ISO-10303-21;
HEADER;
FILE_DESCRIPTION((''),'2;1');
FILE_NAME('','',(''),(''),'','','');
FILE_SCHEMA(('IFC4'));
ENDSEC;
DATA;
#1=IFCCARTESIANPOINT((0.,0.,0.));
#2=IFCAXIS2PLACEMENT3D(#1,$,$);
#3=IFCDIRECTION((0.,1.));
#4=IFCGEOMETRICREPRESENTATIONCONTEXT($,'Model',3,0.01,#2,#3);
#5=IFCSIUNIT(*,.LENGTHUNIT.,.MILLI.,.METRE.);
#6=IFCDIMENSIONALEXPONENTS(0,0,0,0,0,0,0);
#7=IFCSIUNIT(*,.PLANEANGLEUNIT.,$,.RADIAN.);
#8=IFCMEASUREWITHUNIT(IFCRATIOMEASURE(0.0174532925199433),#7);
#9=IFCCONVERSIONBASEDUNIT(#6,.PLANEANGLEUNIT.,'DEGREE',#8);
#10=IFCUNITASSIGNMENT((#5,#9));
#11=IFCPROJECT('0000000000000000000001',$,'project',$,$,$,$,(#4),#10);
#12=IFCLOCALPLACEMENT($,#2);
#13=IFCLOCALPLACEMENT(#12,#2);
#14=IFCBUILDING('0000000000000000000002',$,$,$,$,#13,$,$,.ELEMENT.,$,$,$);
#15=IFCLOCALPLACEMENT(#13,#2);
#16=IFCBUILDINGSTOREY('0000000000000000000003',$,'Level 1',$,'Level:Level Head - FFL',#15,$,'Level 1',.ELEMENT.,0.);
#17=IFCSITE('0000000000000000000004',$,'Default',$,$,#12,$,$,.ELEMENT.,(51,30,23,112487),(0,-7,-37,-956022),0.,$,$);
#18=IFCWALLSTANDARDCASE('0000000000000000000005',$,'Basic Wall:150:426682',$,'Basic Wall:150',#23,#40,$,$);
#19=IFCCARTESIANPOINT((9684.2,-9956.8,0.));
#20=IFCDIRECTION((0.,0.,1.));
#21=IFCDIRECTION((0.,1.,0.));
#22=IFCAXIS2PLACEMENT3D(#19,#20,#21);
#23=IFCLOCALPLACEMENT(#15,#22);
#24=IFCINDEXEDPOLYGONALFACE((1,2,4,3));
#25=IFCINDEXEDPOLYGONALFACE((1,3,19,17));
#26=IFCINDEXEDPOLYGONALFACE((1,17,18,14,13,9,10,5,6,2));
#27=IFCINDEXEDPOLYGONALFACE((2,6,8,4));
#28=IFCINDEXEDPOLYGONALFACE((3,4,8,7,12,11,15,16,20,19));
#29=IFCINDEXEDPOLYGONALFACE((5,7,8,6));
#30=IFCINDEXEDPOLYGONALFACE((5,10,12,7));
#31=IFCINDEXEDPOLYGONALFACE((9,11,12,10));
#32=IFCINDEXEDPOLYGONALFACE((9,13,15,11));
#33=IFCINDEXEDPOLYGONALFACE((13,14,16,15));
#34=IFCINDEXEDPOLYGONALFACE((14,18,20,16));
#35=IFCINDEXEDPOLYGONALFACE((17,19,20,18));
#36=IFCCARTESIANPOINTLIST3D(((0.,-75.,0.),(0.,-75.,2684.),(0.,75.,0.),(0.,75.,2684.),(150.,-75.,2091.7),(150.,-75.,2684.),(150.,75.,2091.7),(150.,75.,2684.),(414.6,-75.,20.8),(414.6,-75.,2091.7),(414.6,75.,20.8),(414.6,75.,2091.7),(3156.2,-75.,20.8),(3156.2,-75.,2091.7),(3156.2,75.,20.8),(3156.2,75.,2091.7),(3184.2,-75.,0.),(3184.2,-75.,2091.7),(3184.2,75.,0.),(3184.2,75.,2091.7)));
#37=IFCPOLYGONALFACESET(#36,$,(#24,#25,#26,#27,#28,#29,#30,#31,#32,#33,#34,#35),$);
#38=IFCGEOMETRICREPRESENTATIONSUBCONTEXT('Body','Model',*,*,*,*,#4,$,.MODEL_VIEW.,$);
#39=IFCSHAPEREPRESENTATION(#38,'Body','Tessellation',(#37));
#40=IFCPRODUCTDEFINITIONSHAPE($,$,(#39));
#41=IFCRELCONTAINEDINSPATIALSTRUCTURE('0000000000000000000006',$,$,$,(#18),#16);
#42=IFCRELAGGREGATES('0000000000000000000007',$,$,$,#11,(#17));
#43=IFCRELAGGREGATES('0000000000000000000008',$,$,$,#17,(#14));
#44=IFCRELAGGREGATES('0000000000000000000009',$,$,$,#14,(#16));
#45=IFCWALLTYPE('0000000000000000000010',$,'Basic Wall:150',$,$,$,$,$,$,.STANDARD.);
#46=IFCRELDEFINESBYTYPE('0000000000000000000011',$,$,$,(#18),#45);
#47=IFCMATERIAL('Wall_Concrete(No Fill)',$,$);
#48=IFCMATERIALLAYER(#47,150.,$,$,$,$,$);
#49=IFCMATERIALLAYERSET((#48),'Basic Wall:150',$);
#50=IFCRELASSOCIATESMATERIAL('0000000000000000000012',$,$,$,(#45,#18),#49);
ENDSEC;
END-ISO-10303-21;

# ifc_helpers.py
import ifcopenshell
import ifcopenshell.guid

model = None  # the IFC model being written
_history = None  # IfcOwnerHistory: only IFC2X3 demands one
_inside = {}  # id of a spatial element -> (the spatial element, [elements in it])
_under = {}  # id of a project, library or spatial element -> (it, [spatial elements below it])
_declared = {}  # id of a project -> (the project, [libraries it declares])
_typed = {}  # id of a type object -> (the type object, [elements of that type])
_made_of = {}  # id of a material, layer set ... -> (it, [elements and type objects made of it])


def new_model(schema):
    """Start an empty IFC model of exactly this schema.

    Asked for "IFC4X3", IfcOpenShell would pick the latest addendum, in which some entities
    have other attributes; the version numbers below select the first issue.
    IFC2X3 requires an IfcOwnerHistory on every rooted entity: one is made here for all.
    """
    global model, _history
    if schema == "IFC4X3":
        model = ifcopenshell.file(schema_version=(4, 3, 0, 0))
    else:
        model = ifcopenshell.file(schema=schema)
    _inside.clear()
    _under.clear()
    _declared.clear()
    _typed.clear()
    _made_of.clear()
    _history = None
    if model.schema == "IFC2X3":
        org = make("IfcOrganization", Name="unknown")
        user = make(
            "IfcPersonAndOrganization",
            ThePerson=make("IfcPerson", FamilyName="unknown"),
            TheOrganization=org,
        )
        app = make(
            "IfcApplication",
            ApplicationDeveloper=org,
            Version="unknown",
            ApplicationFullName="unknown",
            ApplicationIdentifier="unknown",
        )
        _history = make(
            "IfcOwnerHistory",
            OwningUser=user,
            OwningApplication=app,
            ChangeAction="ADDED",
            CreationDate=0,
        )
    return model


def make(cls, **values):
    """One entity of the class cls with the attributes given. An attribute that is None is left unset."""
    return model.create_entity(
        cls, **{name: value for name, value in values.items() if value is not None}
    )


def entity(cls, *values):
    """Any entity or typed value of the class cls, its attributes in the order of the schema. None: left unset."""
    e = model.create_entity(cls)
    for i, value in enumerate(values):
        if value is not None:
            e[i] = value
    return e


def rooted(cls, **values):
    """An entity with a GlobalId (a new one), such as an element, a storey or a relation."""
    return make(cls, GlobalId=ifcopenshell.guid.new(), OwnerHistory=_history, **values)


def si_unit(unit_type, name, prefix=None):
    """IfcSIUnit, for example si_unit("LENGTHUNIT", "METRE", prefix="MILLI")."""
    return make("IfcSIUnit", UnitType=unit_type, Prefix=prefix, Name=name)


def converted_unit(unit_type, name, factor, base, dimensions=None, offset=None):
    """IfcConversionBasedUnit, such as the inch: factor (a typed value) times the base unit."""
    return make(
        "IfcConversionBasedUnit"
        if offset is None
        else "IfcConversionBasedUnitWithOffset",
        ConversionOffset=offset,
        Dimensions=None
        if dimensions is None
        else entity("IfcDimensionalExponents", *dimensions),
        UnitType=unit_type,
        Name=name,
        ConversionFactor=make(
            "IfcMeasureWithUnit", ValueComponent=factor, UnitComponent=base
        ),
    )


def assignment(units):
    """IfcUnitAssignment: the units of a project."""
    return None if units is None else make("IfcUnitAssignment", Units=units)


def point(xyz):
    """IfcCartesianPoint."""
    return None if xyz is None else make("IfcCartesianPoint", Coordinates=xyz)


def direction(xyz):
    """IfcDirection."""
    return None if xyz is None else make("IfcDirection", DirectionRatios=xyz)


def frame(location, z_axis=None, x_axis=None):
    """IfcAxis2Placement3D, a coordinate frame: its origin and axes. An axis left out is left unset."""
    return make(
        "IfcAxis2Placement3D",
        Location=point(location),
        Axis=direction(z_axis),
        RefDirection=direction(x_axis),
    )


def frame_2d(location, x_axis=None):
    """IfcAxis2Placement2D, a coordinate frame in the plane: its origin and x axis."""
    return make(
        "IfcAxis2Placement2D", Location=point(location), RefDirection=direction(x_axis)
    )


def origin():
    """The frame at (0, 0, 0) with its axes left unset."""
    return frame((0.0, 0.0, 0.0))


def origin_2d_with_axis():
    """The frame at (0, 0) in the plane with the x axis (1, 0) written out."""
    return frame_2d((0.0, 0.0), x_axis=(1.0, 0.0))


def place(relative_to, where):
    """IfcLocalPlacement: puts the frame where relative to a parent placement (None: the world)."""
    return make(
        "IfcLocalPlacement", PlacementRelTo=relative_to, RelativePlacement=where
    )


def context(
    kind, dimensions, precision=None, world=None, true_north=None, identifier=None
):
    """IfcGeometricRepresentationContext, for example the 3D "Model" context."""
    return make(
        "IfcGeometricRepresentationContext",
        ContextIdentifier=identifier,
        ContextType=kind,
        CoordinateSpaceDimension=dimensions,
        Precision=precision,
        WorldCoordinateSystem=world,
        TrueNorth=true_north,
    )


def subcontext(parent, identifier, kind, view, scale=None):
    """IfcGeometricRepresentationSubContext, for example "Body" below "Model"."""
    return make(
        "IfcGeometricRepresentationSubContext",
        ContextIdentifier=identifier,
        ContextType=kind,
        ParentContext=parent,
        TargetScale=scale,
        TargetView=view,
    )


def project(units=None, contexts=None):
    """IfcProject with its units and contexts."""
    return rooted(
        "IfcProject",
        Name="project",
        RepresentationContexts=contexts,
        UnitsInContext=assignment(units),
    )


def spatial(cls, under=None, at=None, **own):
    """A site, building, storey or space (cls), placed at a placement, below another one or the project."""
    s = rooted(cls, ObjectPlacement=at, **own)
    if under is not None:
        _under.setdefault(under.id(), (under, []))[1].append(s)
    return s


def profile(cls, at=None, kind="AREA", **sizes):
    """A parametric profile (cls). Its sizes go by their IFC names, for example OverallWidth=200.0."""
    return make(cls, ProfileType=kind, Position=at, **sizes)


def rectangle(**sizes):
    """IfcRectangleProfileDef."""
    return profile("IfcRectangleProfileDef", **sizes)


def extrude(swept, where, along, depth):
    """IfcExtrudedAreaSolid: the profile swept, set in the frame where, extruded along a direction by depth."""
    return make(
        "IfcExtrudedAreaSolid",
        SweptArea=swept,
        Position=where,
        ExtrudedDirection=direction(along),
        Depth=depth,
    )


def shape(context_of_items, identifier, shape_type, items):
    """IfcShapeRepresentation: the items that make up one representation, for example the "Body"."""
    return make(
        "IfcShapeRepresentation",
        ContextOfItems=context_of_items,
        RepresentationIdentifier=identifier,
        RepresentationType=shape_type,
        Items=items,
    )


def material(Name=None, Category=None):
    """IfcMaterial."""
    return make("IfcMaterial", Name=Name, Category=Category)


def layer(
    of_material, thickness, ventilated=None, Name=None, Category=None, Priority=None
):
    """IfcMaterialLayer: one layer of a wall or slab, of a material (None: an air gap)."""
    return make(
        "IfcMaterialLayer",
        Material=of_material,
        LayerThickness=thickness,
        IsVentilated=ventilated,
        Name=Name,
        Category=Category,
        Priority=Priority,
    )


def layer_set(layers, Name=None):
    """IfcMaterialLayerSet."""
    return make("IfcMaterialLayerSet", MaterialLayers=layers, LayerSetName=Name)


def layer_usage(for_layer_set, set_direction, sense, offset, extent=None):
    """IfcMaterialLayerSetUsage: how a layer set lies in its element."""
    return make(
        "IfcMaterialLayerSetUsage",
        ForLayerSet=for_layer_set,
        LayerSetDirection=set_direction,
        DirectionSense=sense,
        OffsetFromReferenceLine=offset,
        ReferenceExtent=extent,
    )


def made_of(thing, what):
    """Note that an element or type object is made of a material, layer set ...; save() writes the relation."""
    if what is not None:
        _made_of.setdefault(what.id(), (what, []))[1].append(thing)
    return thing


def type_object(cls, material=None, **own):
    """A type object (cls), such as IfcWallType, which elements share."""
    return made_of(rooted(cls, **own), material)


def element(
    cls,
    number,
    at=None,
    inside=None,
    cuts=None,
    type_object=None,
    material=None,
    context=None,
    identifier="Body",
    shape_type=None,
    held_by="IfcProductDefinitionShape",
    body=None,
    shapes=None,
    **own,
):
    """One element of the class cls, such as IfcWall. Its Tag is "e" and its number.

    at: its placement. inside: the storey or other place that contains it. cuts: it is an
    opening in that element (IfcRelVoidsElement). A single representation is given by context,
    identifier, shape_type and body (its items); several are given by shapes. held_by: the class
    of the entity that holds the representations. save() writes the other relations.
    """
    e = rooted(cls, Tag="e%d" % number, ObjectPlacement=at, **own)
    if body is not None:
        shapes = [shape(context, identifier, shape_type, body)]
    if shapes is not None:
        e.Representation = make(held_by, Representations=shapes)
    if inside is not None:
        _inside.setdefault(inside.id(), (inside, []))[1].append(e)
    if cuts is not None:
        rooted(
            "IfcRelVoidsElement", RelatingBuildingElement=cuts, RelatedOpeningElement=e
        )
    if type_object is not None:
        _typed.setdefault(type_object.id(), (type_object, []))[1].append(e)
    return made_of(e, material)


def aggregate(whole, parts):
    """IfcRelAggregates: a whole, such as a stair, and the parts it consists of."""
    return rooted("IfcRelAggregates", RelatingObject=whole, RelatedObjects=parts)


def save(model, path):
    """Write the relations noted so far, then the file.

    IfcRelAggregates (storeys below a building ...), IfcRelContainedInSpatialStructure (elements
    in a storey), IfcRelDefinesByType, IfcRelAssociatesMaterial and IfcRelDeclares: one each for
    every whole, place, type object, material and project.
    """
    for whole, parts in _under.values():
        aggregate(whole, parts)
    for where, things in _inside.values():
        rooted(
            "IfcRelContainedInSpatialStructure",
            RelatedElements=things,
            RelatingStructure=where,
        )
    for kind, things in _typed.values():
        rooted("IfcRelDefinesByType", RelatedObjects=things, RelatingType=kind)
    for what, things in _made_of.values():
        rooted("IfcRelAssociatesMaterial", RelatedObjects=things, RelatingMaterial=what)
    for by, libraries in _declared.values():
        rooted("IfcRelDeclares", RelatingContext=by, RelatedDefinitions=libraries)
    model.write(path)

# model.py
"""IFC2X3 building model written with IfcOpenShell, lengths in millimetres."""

from ifc_helpers import new_model, entity, si_unit, converted_unit, direction, frame, frame_2d, origin, origin_2d_with_axis, place, context, subcontext, project, spatial, rectangle, extrude, material, layer, layer_set, layer_usage, type_object, element, save


model = new_model("IFC2X3")

# Units and contexts
model_context = context("Model", 3, precision=0.01, world=origin(), true_north=direction((0.0, 1.0)))
body_context = subcontext(model_context, "Body", "Model", "MODEL_VIEW")
ifc_project = project(units=[si_unit("LENGTHUNIT", "METRE", prefix="MILLI"), converted_unit("PLANEANGLEUNIT", "DEGREE", entity("IfcRatioMeasure", 0.0174532925199433), si_unit("PLANEANGLEUNIT", "RADIAN"), dimensions=[0, 0, 0, 0, 0, 0, 0])], contexts=[model_context])

# Site, building, storey
site_placement = place(None, origin())
site = spatial("IfcSite", under=ifc_project, at=site_placement, Name="Default", CompositionType="ELEMENT", RefLatitude=(51, 30, 23, 112487), RefLongitude=(0, -7, -37, -956022), RefElevation=0.0)
building_placement = place(site_placement, origin())
building = spatial("IfcBuilding", under=site, at=building_placement, CompositionType="ELEMENT")
storey_placement = place(building_placement, origin())
storey = spatial("IfcBuildingStorey", under=building, at=storey_placement, Name="Level 1", ObjectType="Level:Level Head - FFL", LongName="Level 1", CompositionType="ELEMENT", Elevation=0.0)

# Wall, openings
ifc_material_1 = material(Name="Wall_Concrete(No Fill)")
ifc_layer_1 = layer(ifc_material_1, 150.0)
ifc_layer_set_1 = layer_set([ifc_layer_1], Name="Basic Wall:150")
ifc_layer_usage_1 = layer_usage(ifc_layer_set_1, "AXIS2", "NEGATIVE", 75.0)
wall_type_1 = type_object("IfcWallType", Name="Basic Wall:150", PredefinedType="STANDARD", material=ifc_layer_set_1)
wall_1_placement = place(storey_placement, frame((9684.2, -9956.8, 0.0), z_axis=(0.0, 0.0, 1.0), x_axis=(0.0, 1.0, 0.0)))
wall_1 = element("IfcWallStandardCase", 1, at=wall_1_placement, inside=storey, type_object=wall_type_1, material=ifc_layer_usage_1, Name="Basic Wall:150:426682", ObjectType="Basic Wall:150", context=body_context, shape_type="SweptSolid", body=[
    extrude(rectangle(XDim=3184.2, YDim=150.0, at=frame_2d((1592.1, 0.0), x_axis=(-1.0, 0.0))), origin(), (0.0, 0.0, 1.0), 2684.0),
])
opening_1_placement = place(wall_1_placement, origin())
element("IfcOpeningElement", 2, at=opening_1_placement, cuts=wall_1, ObjectType="Opening", context=body_context, shape_type="SweptSolid", body=[
    extrude(rectangle(XDim=792.3, YDim=3034.2, at=frame_2d((0.0, 0.0), x_axis=(1.0, 0.0))), frame((1667.1, -75.0, 2487.8), z_axis=(0.0, 1.0, 0.0), x_axis=(0.0, 0.0, -1.0)), (0.0, 0.0, 1.0), 150.0),
])
opening_2_placement = place(wall_1_placement, origin())
element("IfcOpeningElement", 3, at=opening_2_placement, cuts=wall_1, ObjectType="Opening", context=body_context, shape_type="SweptSolid", body=[
    extrude(rectangle(XDim=2159.1, YDim=2741.6, at=origin_2d_with_axis()), frame((1785.4, -75.0, 1100.3), z_axis=(0.0, 1.0, 0.0), x_axis=(0.0, 0.0, -1.0)), (0.0, 0.0, 1.0), 150.0),
])

save(model, "model.ifc")
